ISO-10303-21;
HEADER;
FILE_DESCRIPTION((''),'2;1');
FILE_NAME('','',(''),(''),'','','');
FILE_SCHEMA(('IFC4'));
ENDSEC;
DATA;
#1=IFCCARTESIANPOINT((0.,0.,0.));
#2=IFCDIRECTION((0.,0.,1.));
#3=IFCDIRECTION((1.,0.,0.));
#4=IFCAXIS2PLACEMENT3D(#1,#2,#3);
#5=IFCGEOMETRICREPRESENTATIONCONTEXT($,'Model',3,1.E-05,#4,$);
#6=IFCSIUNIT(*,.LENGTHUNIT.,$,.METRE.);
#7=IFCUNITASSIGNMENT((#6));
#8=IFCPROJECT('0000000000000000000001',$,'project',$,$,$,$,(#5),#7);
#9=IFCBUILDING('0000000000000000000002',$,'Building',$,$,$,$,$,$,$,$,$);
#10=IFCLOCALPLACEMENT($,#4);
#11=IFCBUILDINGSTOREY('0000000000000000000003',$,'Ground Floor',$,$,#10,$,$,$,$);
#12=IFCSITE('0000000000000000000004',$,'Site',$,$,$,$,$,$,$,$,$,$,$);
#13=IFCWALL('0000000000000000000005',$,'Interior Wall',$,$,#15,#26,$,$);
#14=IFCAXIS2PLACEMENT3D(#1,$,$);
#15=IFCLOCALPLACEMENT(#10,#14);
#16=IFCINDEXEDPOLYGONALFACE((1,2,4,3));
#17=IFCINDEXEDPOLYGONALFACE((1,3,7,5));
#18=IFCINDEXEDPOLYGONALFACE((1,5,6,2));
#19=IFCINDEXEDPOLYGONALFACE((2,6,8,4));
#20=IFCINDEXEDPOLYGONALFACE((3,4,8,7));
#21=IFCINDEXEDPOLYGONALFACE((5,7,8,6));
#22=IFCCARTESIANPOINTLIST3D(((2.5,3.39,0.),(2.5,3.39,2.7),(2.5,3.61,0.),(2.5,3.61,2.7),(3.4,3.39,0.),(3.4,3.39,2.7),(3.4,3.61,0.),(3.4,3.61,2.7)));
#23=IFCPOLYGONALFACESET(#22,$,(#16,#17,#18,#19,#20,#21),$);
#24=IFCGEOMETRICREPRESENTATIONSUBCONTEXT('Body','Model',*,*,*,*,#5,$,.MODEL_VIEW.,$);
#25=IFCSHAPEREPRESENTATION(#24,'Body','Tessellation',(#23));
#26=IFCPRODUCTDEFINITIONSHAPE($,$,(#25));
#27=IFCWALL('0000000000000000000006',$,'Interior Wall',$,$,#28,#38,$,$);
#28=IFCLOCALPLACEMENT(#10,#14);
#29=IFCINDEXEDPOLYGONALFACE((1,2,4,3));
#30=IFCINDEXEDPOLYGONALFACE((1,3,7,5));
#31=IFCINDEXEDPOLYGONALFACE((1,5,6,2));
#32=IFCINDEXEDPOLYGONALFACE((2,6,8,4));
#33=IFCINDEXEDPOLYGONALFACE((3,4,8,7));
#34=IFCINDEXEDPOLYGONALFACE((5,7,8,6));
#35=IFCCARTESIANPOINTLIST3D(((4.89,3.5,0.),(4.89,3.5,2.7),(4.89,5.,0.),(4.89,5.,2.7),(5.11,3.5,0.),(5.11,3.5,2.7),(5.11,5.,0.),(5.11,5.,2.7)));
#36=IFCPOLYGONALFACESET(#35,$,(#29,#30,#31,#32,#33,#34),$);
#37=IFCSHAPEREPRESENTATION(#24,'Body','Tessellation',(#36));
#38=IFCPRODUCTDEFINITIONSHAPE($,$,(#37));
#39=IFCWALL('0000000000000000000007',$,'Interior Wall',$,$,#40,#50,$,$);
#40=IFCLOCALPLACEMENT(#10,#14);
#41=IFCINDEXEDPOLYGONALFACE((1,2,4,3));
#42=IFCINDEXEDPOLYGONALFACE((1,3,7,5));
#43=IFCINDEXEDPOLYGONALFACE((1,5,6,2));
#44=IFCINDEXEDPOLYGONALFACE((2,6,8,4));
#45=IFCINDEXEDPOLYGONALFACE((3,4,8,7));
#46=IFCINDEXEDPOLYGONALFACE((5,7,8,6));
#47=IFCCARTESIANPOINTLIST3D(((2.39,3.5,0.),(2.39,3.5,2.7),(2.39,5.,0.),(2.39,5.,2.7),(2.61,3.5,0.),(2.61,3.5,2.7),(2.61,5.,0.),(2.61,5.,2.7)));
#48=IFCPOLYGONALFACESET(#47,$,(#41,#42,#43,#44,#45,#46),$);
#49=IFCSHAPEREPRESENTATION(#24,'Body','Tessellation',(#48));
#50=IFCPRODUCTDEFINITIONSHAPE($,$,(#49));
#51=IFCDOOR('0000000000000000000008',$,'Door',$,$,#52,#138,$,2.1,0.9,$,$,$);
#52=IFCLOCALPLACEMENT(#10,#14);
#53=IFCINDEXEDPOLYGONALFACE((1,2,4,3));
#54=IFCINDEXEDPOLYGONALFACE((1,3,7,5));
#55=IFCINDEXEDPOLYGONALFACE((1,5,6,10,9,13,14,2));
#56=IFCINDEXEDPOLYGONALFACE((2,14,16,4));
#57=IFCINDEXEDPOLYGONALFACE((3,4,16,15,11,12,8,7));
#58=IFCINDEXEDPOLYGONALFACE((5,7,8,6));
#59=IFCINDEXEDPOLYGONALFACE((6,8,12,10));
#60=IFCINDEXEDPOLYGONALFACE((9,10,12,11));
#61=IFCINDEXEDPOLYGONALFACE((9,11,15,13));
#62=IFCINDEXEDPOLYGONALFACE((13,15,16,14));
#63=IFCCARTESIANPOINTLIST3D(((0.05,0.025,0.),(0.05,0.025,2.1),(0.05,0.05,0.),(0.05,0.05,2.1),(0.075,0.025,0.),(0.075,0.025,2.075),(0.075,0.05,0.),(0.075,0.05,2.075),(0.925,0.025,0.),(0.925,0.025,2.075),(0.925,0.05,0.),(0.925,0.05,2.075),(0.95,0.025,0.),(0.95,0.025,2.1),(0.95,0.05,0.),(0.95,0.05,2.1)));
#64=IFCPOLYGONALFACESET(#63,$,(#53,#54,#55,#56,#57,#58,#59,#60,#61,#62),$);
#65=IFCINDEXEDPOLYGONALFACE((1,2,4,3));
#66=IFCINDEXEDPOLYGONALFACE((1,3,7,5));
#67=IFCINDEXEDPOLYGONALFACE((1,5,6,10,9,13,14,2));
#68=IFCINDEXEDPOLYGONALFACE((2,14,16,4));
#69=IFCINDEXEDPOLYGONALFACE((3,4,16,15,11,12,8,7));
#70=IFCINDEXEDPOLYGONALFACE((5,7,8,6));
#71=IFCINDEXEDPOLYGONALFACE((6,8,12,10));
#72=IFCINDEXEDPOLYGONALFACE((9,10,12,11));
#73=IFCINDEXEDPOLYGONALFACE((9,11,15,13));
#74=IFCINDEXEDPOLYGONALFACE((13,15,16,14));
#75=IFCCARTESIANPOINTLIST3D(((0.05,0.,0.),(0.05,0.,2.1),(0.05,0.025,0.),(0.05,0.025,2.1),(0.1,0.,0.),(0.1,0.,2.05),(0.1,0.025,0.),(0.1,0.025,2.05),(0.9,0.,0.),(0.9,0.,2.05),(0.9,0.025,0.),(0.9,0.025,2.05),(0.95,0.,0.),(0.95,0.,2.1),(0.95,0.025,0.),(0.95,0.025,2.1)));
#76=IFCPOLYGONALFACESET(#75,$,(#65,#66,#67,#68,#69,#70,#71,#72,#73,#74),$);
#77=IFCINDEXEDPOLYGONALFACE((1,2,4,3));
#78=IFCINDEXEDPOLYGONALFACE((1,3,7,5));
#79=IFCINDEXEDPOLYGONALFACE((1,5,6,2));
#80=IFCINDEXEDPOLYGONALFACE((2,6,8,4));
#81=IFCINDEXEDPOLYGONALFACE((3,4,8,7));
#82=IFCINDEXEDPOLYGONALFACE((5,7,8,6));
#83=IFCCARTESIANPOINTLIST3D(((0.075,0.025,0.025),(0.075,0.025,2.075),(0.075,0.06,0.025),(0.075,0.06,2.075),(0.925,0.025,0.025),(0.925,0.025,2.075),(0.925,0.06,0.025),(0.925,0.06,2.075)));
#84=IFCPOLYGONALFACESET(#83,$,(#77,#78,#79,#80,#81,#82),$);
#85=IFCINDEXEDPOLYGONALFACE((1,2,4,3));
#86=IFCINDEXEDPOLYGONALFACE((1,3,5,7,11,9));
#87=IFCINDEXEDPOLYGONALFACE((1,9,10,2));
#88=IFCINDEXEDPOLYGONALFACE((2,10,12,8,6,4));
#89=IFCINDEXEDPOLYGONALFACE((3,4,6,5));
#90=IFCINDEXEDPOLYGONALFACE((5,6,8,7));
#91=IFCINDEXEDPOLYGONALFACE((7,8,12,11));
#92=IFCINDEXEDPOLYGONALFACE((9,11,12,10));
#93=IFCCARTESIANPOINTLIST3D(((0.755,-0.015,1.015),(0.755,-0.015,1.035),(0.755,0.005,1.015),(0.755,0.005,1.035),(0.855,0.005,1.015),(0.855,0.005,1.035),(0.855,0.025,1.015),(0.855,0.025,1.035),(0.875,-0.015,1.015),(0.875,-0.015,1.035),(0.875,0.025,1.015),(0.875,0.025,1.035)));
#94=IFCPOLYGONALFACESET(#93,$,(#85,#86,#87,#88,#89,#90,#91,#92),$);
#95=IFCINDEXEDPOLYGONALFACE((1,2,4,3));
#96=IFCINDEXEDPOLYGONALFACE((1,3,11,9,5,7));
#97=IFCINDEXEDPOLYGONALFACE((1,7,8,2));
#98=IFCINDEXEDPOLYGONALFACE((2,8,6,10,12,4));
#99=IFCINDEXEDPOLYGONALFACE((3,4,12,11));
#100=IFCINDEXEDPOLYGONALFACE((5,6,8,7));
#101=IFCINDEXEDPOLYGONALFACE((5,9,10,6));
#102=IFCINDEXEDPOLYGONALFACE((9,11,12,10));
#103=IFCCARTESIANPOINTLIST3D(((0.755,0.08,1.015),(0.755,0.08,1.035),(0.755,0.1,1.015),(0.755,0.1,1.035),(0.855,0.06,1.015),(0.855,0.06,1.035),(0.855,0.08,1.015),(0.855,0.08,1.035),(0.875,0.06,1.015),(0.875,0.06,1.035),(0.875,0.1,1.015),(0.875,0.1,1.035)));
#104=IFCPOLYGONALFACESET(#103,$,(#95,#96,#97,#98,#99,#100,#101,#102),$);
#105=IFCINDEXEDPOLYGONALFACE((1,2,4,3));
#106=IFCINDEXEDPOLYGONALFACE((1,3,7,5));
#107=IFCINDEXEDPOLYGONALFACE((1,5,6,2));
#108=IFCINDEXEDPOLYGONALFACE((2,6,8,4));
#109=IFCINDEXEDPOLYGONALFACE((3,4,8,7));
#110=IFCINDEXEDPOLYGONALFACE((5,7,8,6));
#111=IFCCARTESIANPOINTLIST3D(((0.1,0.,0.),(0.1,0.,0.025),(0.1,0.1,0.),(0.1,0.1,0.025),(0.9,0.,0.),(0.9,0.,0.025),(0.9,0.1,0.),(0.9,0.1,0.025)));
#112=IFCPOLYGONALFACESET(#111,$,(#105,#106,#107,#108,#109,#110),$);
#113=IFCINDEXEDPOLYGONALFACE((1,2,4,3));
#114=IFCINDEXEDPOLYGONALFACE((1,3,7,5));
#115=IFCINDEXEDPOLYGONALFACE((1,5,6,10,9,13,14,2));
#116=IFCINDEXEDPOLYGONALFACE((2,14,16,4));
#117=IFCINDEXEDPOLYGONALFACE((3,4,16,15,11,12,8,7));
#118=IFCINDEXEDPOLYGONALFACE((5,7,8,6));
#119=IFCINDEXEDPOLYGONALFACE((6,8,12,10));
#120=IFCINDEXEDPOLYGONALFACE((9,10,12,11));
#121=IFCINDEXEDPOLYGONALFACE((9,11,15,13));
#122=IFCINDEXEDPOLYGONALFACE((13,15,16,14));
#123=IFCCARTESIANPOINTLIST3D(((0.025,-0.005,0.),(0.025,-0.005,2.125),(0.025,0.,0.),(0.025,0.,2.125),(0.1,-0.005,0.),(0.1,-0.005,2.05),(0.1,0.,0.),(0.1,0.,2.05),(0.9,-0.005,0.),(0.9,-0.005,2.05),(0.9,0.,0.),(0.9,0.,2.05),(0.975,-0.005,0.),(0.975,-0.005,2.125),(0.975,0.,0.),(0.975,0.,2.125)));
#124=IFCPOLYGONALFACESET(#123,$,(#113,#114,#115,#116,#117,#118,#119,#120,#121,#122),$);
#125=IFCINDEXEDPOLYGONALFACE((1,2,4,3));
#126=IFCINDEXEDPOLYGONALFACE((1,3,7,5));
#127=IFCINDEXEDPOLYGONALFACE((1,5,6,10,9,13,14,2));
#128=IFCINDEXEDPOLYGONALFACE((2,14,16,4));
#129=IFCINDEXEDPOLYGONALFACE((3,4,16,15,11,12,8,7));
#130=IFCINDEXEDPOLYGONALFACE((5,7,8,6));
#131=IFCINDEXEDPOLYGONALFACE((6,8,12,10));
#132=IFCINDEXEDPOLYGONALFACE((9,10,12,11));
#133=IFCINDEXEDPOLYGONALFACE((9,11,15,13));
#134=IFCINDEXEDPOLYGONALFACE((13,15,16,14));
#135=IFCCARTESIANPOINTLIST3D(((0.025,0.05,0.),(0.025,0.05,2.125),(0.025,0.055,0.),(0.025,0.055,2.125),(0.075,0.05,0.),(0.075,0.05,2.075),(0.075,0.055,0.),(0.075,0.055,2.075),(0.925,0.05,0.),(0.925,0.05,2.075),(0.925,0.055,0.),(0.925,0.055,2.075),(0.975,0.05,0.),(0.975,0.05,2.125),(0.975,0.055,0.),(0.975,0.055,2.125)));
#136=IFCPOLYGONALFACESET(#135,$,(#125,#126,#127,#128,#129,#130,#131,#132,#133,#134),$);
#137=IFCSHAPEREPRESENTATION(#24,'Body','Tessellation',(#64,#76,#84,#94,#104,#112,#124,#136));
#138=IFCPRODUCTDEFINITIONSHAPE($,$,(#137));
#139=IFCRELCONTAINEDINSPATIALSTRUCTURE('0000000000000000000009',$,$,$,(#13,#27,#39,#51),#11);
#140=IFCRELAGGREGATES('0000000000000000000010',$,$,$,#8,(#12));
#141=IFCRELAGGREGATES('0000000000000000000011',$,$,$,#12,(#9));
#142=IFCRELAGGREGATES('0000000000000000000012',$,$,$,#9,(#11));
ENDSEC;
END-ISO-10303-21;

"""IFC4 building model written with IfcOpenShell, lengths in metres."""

from ifc_helpers import new_model, si_unit, frame, origin_with_axes, place, context, subcontext, project, spatial, line, indexed_curve, outline, extrude, element, save


model = new_model("IFC4")

# Units and contexts
model_context = context("Model", 3, precision=1e-05, world=origin_with_axes())
body_context = subcontext(model_context, "Body", "Model", "MODEL_VIEW")
ifc_project = project(units=[si_unit("LENGTHUNIT", "METRE")], contexts=[model_context])

# Site, building, storey
site = spatial("IfcSite", under=ifc_project, Name="Site")
building = spatial("IfcBuilding", under=site, Name="Building")
storey_placement = place(None, origin_with_axes())
storey = spatial("IfcBuildingStorey", under=building, at=storey_placement, Name="Ground Floor")

# Walls
wall_1_placement = place(storey_placement, frame((3.4, 3.5, 0.0), z_axis=(0.0, 0.0, 1.0), x_axis=(-1.0, 0.0, 0.0)))
element("IfcWall", 1, at=wall_1_placement, inside=storey, Name="Interior Wall", context=body_context, shape_type="SweptSolid", body=[
    extrude(outline(indexed_curve([(0.0, 0.0), (0.0, 0.22), (0.9, 0.22), (0.9, 0.0), (0.0, 0.0)], self_intersect=False)), frame((0.0, -0.11, 0.0), z_axis=(0.0, 0.0, 1.0), x_axis=(1.0, 0.0, 0.0)), (0.0, 0.0, 1.0), 2.7),
])
for number, where, z_axis, x_axis, name in (
    (2, (5.0, 5.0, 0.0), (0.0, 0.0, 1.0), (0.0, -1.0, 0.0), "Interior Wall"),
    (3, (2.5, 3.5, 0.0), (0.0, 0.0, 1.0), (0.0, 1.0, 0.0), "Interior Wall"),
):
    element("IfcWall", number, at=place(storey_placement, frame(where, z_axis=z_axis, x_axis=x_axis)), inside=storey, Name=name, context=body_context, shape_type="SweptSolid", body=[
        extrude(outline(indexed_curve([(0.0, 0.0), (0.0, 0.22), (1.5, 0.22), (1.5, 0.0), (0.0, 0.0)], self_intersect=False)), frame((0.0, -0.11, 0.0), z_axis=(0.0, 0.0, 1.0), x_axis=(1.0, 0.0, 0.0)), (0.0, 0.0, 1.0), 2.7),
    ])

# Door
door_1_placement = place(storey_placement, frame((0.05, 0.0, 0.0), z_axis=(0.0, 0.0, 1.0), x_axis=(1.0, 0.0, 0.0)))
element("IfcDoor", 4, at=door_1_placement, inside=storey, Name="Door", OverallHeight=2.1, OverallWidth=0.9, context=body_context, shape_type="SweptSolid", body=[
    extrude(outline(indexed_curve([(0.0, 0.0), (0.0, 2.1), (0.9, 2.1), (0.9, 0.0), (0.875, 0.0), (0.875, 2.075), (0.025, 2.075), (0.025, 0.0)], segments=[line(1, 2, 3, 4, 5, 6, 7, 8, 1)])), frame((0.0, 0.025, 0.0), z_axis=(0.0, -1.0, 0.0), x_axis=(1.0, 0.0, 0.0)), (0.0, 0.0, -1.0), 0.025),
    extrude(outline(indexed_curve([(0.0, 0.0), (0.0, 2.1), (0.9, 2.1), (0.9, 0.0), (0.85, 0.0), (0.85, 2.05), (0.05, 2.05), (0.05, 0.0)], segments=[line(1, 2, 3, 4, 5, 6, 7, 8, 1)])), frame((0.0, 0.0, 0.0), z_axis=(0.0, -1.0, 0.0), x_axis=(1.0, 0.0, 0.0)), (0.0, 0.0, -1.0), 0.025),
    extrude(outline(indexed_curve([(0.0, 0.0), (0.85, 0.0), (0.85, 0.035), (0.0, 0.035)], segments=[line(1, 2, 3, 4, 1)])), frame((0.025, 0.025, 0.025), z_axis=(0.0, 0.0, 1.0), x_axis=(1.0, 0.0, 0.0)), (0.0, 0.0, 1.0), 2.05),
    extrude(outline(indexed_curve([(0.0, 0.0), (0.0, -0.04), (-0.12, -0.04), (-0.12, -0.02), (-0.02, -0.02), (-0.02, 0.0)], segments=[line(1, 2, 3, 4, 5, 6, 1)])), frame((0.825, 0.025, 1.015), z_axis=(0.0, 0.0, 1.0), x_axis=(1.0, 0.0, 0.0)), (0.0, 0.0, 1.0), 0.02),
    extrude(outline(indexed_curve([(0.0, 0.0), (0.0, 0.04), (-0.12, 0.04), (-0.12, 0.02), (-0.02, 0.02), (-0.02, 0.0)], segments=[line(1, 2, 3, 4, 5, 6, 1)])), frame((0.825, 0.06, 1.015), z_axis=(0.0, 0.0, 1.0), x_axis=(1.0, 0.0, 0.0)), (0.0, 0.0, 1.0), 0.02),
    extrude(outline(indexed_curve([(0.0, 0.0), (0.8, 0.0), (0.8, 0.1), (0.0, 0.1)], segments=[line(1, 2, 3, 4, 1)])), frame((0.05, 0.0, 0.0), z_axis=(0.0, 0.0, 1.0), x_axis=(1.0, 0.0, 0.0)), (0.0, 0.0, 1.0), 0.025),
    extrude(outline(indexed_curve([(0.0, 0.0), (0.0, 2.125), (0.95, 2.125), (0.95, 0.0), (0.875, 0.0), (0.875, 2.05), (0.075, 2.05), (0.075, 0.0)], segments=[line(1, 2, 3, 4, 5, 6, 7, 8, 1)])), frame((-0.025, -0.005, 0.0), z_axis=(0.0, -1.0, 0.0), x_axis=(1.0, 0.0, 0.0)), (0.0, 0.0, -1.0), 0.005),
    extrude(outline(indexed_curve([(0.0, 0.0), (0.0, 2.125), (0.95, 2.125), (0.95, 0.0), (0.9, 0.0), (0.9, 2.075), (0.05, 2.075), (0.05, 0.0)], segments=[line(1, 2, 3, 4, 5, 6, 7, 8, 1)])), frame((-0.025, 0.05, 0.0), z_axis=(0.0, -1.0, 0.0), x_axis=(1.0, 0.0, 0.0)), (0.0, 0.0, -1.0), 0.005),
])

save(model, "model.ifc")
